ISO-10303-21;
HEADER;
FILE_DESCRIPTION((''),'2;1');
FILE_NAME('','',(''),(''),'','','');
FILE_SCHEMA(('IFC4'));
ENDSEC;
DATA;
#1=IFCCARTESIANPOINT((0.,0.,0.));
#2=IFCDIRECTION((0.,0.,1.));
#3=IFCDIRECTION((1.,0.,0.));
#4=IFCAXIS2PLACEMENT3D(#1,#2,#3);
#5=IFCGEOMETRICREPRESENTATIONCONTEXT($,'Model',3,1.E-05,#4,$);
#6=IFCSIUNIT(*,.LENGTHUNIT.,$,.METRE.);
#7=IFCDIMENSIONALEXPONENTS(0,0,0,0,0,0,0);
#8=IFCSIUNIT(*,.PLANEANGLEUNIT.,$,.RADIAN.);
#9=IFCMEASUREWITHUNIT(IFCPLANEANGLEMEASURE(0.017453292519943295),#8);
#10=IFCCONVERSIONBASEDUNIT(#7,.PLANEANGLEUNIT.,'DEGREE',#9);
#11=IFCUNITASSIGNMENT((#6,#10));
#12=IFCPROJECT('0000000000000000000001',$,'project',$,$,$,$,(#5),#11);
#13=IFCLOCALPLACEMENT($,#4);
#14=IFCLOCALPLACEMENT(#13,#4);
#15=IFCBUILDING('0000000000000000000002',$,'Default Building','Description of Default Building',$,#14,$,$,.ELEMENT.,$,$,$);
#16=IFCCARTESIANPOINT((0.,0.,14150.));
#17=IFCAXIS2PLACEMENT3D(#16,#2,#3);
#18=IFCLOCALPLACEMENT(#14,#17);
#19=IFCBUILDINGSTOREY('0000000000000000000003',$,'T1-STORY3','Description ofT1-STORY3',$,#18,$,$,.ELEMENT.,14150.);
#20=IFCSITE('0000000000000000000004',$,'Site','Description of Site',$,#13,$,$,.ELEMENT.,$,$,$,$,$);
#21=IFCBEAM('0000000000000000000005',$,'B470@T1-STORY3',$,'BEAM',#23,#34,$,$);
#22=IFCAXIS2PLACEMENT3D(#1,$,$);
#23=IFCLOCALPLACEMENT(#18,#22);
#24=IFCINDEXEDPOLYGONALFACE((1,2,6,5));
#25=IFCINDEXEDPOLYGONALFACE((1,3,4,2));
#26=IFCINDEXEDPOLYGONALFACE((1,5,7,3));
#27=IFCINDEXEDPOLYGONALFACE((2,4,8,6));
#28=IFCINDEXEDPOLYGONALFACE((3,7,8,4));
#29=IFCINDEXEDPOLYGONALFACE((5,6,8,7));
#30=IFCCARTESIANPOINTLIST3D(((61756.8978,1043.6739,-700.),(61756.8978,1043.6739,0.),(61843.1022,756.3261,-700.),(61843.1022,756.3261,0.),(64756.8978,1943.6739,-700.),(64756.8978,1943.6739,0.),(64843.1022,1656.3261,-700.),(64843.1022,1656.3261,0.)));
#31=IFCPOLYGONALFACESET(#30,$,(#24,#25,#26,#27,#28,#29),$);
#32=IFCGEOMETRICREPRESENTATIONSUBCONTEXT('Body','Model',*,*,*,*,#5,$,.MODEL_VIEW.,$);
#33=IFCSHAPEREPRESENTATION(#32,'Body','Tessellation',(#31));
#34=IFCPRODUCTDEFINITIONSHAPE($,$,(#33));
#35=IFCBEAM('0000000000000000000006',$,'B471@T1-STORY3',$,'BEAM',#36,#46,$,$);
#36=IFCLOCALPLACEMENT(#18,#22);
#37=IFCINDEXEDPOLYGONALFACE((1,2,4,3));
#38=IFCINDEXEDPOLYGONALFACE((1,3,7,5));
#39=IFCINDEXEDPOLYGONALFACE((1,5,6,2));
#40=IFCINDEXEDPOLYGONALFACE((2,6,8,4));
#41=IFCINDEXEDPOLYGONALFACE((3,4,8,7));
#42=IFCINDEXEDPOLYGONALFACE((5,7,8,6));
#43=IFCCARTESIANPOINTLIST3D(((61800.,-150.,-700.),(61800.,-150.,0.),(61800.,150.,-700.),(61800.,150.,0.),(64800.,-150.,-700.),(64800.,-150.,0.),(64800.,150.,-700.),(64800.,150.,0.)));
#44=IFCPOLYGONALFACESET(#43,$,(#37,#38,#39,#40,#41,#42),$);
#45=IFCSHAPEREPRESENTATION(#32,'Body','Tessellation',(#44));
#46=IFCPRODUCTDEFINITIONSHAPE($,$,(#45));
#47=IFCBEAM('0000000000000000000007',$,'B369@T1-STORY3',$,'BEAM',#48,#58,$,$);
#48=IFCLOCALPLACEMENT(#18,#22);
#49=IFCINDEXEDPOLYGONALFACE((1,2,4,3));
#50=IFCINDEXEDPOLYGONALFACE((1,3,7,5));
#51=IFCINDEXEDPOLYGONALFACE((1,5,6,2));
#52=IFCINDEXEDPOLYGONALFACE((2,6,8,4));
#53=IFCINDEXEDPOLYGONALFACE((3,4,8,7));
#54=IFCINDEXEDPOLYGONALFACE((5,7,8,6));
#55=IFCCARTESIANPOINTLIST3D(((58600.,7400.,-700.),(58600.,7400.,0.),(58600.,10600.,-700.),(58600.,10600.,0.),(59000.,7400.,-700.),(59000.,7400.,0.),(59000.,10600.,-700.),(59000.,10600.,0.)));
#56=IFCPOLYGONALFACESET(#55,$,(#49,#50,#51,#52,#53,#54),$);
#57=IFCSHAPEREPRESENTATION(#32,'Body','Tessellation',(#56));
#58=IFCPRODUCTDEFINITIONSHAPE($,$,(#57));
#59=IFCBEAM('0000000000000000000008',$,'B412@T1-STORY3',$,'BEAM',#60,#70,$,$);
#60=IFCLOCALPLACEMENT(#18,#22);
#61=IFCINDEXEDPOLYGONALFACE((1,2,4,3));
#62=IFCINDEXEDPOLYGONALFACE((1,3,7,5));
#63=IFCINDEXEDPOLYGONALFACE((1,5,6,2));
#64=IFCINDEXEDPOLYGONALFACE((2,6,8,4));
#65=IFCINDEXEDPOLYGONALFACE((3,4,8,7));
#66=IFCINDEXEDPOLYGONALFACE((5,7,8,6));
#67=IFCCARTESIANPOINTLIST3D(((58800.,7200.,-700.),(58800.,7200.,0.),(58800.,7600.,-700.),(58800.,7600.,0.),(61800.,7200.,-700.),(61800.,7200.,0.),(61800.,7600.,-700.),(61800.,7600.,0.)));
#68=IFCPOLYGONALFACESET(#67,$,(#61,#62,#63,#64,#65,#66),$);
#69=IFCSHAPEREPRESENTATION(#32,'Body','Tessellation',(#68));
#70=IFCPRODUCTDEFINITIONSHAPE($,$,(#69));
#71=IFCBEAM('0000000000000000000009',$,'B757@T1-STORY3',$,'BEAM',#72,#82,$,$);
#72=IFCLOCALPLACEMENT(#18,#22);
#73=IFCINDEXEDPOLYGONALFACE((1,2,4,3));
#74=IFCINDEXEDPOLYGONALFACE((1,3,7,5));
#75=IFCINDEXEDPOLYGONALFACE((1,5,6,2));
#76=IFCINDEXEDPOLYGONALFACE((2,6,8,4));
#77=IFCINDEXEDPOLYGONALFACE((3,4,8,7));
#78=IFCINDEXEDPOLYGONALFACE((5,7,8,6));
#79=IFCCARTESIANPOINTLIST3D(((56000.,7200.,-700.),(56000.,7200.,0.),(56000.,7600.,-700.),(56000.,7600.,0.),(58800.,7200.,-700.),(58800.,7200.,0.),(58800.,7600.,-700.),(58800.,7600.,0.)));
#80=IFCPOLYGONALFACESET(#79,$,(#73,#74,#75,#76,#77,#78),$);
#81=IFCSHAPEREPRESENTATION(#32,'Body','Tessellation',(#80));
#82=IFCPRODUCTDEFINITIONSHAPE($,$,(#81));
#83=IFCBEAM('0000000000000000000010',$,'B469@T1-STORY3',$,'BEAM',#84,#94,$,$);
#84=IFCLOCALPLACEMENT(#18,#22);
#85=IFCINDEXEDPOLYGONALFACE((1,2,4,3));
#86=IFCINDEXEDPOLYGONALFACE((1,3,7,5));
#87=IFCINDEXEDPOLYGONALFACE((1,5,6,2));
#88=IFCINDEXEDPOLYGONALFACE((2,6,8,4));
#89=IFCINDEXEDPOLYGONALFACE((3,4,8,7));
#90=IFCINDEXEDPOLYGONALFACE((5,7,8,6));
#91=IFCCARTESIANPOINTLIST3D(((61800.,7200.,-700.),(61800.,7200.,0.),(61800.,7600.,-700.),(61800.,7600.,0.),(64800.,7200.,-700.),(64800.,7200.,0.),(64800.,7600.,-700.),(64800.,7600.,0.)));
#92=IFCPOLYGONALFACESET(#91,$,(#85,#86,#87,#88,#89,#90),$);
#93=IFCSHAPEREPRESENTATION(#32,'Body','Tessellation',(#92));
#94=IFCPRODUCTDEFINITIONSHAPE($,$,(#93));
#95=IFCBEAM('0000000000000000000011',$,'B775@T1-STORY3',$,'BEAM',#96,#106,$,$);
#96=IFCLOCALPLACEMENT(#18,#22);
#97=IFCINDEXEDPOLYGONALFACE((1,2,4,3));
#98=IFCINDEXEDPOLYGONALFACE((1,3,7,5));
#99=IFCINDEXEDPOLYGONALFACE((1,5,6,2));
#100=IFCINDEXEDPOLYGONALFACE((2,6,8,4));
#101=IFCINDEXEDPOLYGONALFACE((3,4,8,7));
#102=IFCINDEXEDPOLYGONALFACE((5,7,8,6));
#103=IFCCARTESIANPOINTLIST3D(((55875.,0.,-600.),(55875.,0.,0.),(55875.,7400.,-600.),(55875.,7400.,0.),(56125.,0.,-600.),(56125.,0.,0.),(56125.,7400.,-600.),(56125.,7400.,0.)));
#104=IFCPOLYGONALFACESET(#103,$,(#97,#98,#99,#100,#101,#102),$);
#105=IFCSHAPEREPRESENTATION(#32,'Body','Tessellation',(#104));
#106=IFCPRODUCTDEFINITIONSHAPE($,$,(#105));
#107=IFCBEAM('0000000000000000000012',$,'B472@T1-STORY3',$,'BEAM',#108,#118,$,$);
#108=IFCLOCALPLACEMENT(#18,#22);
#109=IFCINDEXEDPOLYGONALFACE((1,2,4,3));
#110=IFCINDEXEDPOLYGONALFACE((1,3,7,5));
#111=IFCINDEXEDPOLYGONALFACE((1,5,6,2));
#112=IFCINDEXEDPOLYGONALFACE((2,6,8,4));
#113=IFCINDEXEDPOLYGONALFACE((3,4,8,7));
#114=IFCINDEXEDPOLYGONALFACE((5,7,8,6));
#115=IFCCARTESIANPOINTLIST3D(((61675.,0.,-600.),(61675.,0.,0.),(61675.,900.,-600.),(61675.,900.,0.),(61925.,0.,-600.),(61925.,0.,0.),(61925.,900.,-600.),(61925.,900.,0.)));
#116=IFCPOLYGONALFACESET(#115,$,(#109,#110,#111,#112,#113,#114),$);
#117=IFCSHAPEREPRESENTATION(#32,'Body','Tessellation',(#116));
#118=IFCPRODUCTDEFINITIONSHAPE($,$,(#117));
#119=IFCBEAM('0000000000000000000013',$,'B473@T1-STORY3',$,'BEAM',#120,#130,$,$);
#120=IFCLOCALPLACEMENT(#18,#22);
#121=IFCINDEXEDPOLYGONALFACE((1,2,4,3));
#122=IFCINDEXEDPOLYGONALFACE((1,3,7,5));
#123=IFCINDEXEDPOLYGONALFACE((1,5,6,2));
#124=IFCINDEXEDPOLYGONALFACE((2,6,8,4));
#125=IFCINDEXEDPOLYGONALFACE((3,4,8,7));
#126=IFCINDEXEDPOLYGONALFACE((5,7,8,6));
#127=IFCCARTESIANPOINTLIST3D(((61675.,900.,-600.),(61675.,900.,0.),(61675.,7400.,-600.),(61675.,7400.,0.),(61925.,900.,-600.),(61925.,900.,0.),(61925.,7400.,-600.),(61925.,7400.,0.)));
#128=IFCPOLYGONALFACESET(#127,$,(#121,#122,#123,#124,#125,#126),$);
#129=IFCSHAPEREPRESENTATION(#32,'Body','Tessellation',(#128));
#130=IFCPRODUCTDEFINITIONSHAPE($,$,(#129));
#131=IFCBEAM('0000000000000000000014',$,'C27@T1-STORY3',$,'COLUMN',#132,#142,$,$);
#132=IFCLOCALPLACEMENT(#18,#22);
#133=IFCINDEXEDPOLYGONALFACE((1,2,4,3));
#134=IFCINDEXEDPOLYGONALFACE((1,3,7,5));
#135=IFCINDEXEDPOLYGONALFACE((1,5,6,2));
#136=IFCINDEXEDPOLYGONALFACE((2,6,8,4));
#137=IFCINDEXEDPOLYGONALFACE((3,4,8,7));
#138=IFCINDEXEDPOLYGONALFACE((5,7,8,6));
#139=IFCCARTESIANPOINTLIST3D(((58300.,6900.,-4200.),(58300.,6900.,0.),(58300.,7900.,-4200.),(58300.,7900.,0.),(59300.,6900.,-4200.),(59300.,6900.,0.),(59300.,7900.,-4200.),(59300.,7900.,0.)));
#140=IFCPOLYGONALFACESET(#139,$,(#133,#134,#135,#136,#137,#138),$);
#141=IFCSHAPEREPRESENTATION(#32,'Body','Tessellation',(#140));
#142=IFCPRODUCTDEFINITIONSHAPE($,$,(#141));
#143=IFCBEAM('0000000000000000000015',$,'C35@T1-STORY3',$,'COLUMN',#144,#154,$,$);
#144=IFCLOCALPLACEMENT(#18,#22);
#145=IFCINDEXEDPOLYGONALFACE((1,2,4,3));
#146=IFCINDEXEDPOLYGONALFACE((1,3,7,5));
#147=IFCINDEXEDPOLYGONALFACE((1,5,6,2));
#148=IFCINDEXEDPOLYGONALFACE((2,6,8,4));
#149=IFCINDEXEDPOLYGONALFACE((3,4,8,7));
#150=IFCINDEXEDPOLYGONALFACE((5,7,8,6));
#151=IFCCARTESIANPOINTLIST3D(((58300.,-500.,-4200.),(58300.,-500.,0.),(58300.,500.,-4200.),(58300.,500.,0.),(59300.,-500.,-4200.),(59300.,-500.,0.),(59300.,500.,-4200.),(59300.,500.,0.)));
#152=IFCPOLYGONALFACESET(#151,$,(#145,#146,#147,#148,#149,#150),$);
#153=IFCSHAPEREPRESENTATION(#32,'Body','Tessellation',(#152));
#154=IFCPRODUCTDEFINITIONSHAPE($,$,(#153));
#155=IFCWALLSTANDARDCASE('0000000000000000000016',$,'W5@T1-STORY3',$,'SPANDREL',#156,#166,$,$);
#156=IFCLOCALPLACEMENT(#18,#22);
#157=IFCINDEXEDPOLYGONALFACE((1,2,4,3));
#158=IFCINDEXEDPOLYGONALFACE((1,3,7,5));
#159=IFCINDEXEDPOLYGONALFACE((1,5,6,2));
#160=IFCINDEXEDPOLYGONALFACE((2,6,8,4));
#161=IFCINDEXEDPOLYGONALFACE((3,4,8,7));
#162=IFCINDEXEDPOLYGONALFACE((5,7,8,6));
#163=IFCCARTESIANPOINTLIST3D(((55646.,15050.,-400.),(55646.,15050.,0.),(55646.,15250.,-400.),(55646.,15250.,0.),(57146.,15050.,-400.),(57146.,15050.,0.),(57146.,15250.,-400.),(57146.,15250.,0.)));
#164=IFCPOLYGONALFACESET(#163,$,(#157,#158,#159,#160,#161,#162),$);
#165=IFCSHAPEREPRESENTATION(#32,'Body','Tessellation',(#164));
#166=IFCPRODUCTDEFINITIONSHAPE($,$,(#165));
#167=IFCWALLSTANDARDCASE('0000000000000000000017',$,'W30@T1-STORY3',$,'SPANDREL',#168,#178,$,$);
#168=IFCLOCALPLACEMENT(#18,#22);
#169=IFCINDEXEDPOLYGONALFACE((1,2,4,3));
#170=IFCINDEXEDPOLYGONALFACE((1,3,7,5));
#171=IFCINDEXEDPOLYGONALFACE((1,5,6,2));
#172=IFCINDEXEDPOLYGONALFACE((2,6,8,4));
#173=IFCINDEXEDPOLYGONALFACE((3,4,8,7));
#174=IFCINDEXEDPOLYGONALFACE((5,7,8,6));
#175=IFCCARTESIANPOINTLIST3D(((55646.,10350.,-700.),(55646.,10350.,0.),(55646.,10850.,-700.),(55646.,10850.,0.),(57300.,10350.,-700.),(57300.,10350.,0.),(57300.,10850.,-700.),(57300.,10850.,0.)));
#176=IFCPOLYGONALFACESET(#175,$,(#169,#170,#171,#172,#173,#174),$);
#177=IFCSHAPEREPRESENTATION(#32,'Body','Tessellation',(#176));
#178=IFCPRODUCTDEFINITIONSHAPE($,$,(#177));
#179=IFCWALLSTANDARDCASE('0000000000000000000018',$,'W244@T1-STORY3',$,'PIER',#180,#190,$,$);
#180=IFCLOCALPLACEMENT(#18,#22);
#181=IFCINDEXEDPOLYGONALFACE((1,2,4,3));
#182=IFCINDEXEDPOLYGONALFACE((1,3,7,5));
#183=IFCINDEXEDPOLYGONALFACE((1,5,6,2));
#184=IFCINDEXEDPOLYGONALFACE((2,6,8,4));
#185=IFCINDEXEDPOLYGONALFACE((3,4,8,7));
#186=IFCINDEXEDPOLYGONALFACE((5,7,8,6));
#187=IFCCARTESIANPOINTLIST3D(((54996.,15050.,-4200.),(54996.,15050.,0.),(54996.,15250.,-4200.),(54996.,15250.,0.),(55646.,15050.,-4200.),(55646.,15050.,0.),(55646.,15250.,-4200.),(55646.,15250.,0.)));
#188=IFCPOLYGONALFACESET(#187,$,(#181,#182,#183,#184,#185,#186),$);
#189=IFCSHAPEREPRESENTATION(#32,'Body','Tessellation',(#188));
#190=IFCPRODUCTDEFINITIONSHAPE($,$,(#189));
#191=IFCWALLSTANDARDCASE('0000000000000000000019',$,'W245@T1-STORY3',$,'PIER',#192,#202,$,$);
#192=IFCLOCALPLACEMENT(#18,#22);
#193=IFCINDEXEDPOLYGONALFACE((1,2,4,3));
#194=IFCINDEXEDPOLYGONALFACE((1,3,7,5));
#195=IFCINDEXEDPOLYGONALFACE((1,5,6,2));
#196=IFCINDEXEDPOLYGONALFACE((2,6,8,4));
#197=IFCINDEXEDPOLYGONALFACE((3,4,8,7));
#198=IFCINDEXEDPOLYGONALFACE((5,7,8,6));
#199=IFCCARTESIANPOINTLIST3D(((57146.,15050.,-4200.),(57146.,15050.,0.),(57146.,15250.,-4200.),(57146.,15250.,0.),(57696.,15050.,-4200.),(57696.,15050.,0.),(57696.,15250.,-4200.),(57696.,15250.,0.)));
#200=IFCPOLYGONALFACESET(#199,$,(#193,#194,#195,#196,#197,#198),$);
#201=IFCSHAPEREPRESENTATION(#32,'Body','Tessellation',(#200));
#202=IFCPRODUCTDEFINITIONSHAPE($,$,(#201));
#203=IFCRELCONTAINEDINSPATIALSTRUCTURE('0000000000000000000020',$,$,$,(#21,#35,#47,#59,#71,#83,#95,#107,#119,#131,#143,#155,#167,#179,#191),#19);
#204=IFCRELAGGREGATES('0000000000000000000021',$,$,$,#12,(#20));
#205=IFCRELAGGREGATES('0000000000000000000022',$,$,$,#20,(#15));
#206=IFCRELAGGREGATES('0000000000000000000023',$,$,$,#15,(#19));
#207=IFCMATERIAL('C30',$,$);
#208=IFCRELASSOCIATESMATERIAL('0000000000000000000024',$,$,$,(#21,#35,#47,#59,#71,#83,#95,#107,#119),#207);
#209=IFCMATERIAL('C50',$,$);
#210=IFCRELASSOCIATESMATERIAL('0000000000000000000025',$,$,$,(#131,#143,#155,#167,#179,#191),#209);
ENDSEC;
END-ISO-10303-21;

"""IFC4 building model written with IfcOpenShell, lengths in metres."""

from ifc_helpers import new_model, entity, si_unit, converted_unit, frame, origin_with_axes, place, context, subcontext, project, spatial, indexed_curve, rectangle, outline, extrude, material, element, save


model = new_model("IFC4")

# Units and contexts
model_context = context("Model", 3, precision=1e-05, world=origin_with_axes())
body_context = subcontext(model_context, "Body", "Model", "MODEL_VIEW")
ifc_project = project(units=[si_unit("LENGTHUNIT", "METRE"), converted_unit("PLANEANGLEUNIT", "DEGREE", entity("IfcPlaneAngleMeasure", 0.017453292519943295), si_unit("PLANEANGLEUNIT", "RADIAN"), dimensions=[0, 0, 0, 0, 0, 0, 0])], contexts=[model_context])

# Site, building, storey
site_placement = place(None, origin_with_axes())
site = spatial("IfcSite", under=ifc_project, at=site_placement, Name="Site", Description="Description of Site", CompositionType="ELEMENT")
building_placement = place(site_placement, origin_with_axes())
building = spatial("IfcBuilding", under=site, at=building_placement, Name="Default Building", Description="Description of Default Building", CompositionType="ELEMENT")
storey_placement = place(building_placement, frame((0.0, 0.0, 14150.0), z_axis=(0.0, 0.0, 1.0), x_axis=(1.0, 0.0, 0.0)))
storey = spatial("IfcBuildingStorey", under=building, at=storey_placement, Name="T1-STORY3", Description="Description ofT1-STORY3", CompositionType="ELEMENT", Elevation=14150.0)

# Beams
ifc_material_1 = material(Name="C30")
beam_1_placement = place(storey_placement, frame((61800.0, 900.0, -350.0), z_axis=(0.957826, 0.287348, 0.0), x_axis=(-0.287348, 0.957826, 0.0)))
element("IfcBeam", 1, at=beam_1_placement, inside=storey, material=ifc_material_1, Name="B470@T1-STORY3", ObjectType="BEAM", context=body_context, shape_type="SweptSolid", body=[
    extrude(rectangle(XDim=300.0, YDim=700.0), origin_with_axes(), (0.0, 0.0, 1.0), 3132.092),
])
beam_2_placement = place(storey_placement, frame((61800.0, 0.0, -350.0), z_axis=(1.0, 0.0, 0.0), x_axis=(0.0, 1.0, 0.0)))
element("IfcBeam", 2, at=beam_2_placement, inside=storey, material=ifc_material_1, Name="B471@T1-STORY3", ObjectType="BEAM", context=body_context, shape_type="SweptSolid", body=[
    extrude(rectangle(XDim=300.0, YDim=700.0), origin_with_axes(), (0.0, 0.0, 1.0), 3000.0),
])
beam_3_placement = place(storey_placement, frame((58800.0, 7400.0, -350.0), z_axis=(0.0, 1.0, 0.0), x_axis=(-1.0, 0.0, 0.0)))
element("IfcBeam", 3, at=beam_3_placement, inside=storey, material=ifc_material_1, Name="B369@T1-STORY3", ObjectType="BEAM", context=body_context, shape_type="SweptSolid", body=[
    extrude(rectangle(XDim=400.0, YDim=700.0), origin_with_axes(), (0.0, 0.0, 1.0), 3200.0),
])
beam_4_placement = place(storey_placement, frame((58800.0, 7400.0, -350.0), z_axis=(1.0, 0.0, 0.0), x_axis=(0.0, 1.0, 0.0)))
element("IfcBeam", 4, at=beam_4_placement, inside=storey, material=ifc_material_1, Name="B412@T1-STORY3", ObjectType="BEAM", context=body_context, shape_type="SweptSolid", body=[
    extrude(rectangle(XDim=400.0, YDim=700.0), origin_with_axes(), (0.0, 0.0, 1.0), 3000.0),
])
beam_5_placement = place(storey_placement, frame((56000.0, 7400.0, -350.0), z_axis=(1.0, 0.0, 0.0), x_axis=(0.0, 1.0, 0.0)))
element("IfcBeam", 5, at=beam_5_placement, inside=storey, material=ifc_material_1, Name="B757@T1-STORY3", ObjectType="BEAM", context=body_context, shape_type="SweptSolid", body=[
    extrude(rectangle(XDim=400.0, YDim=700.0), origin_with_axes(), (0.0, 0.0, 1.0), 2800.0),
])
beam_6_placement = place(storey_placement, frame((61800.0, 7400.0, -350.0), z_axis=(1.0, 0.0, 0.0), x_axis=(0.0, 1.0, 0.0)))
element("IfcBeam", 6, at=beam_6_placement, inside=storey, material=ifc_material_1, Name="B469@T1-STORY3", ObjectType="BEAM", context=body_context, shape_type="SweptSolid", body=[
    extrude(rectangle(XDim=400.0, YDim=700.0), origin_with_axes(), (0.0, 0.0, 1.0), 3000.0),
])
beam_7_placement = place(storey_placement, frame((56000.0, 0.0, -300.0), z_axis=(0.0, 1.0, 0.0), x_axis=(-1.0, 0.0, 0.0)))
element("IfcBeam", 7, at=beam_7_placement, inside=storey, material=ifc_material_1, Name="B775@T1-STORY3", ObjectType="BEAM", context=body_context, shape_type="SweptSolid", body=[
    extrude(rectangle(XDim=250.0, YDim=600.0), origin_with_axes(), (0.0, 0.0, 1.0), 7400.0),
])
beam_8_placement = place(storey_placement, frame((61800.0, 0.0, -300.0), z_axis=(0.0, 1.0, 0.0), x_axis=(-1.0, 0.0, 0.0)))
element("IfcBeam", 8, at=beam_8_placement, inside=storey, material=ifc_material_1, Name="B472@T1-STORY3", ObjectType="BEAM", context=body_context, shape_type="SweptSolid", body=[
    extrude(rectangle(XDim=250.0, YDim=600.0), origin_with_axes(), (0.0, 0.0, 1.0), 900.0),
])
beam_9_placement = place(storey_placement, frame((61800.0, 900.0, -300.0), z_axis=(0.0, 1.0, 0.0), x_axis=(-1.0, 0.0, 0.0)))
element("IfcBeam", 9, at=beam_9_placement, inside=storey, material=ifc_material_1, Name="B473@T1-STORY3", ObjectType="BEAM", context=body_context, shape_type="SweptSolid", body=[
    extrude(rectangle(XDim=250.0, YDim=600.0), origin_with_axes(), (0.0, 0.0, 1.0), 6500.0),
])
ifc_material_2 = material(Name="C50")
for number, where, z_axis, x_axis, name in (
    (10, (58800.0, 7400.0, -4200.0), (0.0, 0.0, 1.0), (-1.0, 0.0, 0.0), "C27@T1-STORY3"),
    (11, (58800.0, 0.0, -4200.0), (0.0, 0.0, 1.0), (-1.0, 0.0, 0.0), "C35@T1-STORY3"),
):
    element("IfcBeam", number, at=place(storey_placement, frame(where, z_axis=z_axis, x_axis=x_axis)), inside=storey, material=ifc_material_2, Name=name, ObjectType="COLUMN", context=body_context, shape_type="SweptSolid", body=[
        extrude(rectangle(XDim=1000.0, YDim=1000.0), origin_with_axes(), (0.0, 0.0, 1.0), 4200.0),
    ])

# Walls
wall_1_placement = place(storey_placement, frame((55646.0, 15150.0, -400.0), z_axis=(0.0, 0.0, 1.0), x_axis=(1.0, 0.0, 0.0)))
element("IfcWallStandardCase", 12, at=wall_1_placement, inside=storey, material=ifc_material_2, Name="W5@T1-STORY3", ObjectType="SPANDREL", context=body_context, shape_type="SweptSolid", body=[
    extrude(outline(indexed_curve([(0.0, -100.0), (0.0, 100.0), (1500.0, 100.0), (1500.0, -100.0), (0.0, -100.0)], self_intersect=False)), origin_with_axes(), (0.0, 0.0, 1.0), 400.0),
])
wall_2_placement = place(storey_placement, frame((55646.0, 10600.0, -700.0), z_axis=(0.0, 0.0, 1.0), x_axis=(1.0, 0.0, 0.0)))
element("IfcWallStandardCase", 13, at=wall_2_placement, inside=storey, material=ifc_material_2, Name="W30@T1-STORY3", ObjectType="SPANDREL", context=body_context, shape_type="SweptSolid", body=[
    extrude(outline(indexed_curve([(0.0, -250.0), (0.0, 250.0), (1654.0, 250.0), (1654.0, -250.0), (0.0, -250.0)], self_intersect=False)), origin_with_axes(), (0.0, 0.0, 1.0), 700.0),
])
wall_3_placement = place(storey_placement, frame((54996.0, 15150.0, -4200.0), z_axis=(0.0, 0.0, 1.0), x_axis=(1.0, 0.0, 0.0)))
element("IfcWallStandardCase", 14, at=wall_3_placement, inside=storey, material=ifc_material_2, Name="W244@T1-STORY3", ObjectType="PIER", context=body_context, shape_type="SweptSolid", body=[
    extrude(outline(indexed_curve([(0.0, -100.0), (0.0, 100.0), (650.0, 100.0), (650.0, -100.0), (0.0, -100.0)], self_intersect=False)), origin_with_axes(), (0.0, 0.0, 1.0), 4200.0),
])
wall_4_placement = place(storey_placement, frame((57146.0, 15150.0, -4200.0), z_axis=(0.0, 0.0, 1.0), x_axis=(1.0, 0.0, 0.0)))
element("IfcWallStandardCase", 15, at=wall_4_placement, inside=storey, material=ifc_material_2, Name="W245@T1-STORY3", ObjectType="PIER", context=body_context, shape_type="SweptSolid", body=[
    extrude(outline(indexed_curve([(0.0, -100.0), (0.0, 100.0), (550.0, 100.0), (550.0, -100.0), (0.0, -100.0)], self_intersect=False)), origin_with_axes(), (0.0, 0.0, 1.0), 4200.0),
])

save(model, "model.ifc")
